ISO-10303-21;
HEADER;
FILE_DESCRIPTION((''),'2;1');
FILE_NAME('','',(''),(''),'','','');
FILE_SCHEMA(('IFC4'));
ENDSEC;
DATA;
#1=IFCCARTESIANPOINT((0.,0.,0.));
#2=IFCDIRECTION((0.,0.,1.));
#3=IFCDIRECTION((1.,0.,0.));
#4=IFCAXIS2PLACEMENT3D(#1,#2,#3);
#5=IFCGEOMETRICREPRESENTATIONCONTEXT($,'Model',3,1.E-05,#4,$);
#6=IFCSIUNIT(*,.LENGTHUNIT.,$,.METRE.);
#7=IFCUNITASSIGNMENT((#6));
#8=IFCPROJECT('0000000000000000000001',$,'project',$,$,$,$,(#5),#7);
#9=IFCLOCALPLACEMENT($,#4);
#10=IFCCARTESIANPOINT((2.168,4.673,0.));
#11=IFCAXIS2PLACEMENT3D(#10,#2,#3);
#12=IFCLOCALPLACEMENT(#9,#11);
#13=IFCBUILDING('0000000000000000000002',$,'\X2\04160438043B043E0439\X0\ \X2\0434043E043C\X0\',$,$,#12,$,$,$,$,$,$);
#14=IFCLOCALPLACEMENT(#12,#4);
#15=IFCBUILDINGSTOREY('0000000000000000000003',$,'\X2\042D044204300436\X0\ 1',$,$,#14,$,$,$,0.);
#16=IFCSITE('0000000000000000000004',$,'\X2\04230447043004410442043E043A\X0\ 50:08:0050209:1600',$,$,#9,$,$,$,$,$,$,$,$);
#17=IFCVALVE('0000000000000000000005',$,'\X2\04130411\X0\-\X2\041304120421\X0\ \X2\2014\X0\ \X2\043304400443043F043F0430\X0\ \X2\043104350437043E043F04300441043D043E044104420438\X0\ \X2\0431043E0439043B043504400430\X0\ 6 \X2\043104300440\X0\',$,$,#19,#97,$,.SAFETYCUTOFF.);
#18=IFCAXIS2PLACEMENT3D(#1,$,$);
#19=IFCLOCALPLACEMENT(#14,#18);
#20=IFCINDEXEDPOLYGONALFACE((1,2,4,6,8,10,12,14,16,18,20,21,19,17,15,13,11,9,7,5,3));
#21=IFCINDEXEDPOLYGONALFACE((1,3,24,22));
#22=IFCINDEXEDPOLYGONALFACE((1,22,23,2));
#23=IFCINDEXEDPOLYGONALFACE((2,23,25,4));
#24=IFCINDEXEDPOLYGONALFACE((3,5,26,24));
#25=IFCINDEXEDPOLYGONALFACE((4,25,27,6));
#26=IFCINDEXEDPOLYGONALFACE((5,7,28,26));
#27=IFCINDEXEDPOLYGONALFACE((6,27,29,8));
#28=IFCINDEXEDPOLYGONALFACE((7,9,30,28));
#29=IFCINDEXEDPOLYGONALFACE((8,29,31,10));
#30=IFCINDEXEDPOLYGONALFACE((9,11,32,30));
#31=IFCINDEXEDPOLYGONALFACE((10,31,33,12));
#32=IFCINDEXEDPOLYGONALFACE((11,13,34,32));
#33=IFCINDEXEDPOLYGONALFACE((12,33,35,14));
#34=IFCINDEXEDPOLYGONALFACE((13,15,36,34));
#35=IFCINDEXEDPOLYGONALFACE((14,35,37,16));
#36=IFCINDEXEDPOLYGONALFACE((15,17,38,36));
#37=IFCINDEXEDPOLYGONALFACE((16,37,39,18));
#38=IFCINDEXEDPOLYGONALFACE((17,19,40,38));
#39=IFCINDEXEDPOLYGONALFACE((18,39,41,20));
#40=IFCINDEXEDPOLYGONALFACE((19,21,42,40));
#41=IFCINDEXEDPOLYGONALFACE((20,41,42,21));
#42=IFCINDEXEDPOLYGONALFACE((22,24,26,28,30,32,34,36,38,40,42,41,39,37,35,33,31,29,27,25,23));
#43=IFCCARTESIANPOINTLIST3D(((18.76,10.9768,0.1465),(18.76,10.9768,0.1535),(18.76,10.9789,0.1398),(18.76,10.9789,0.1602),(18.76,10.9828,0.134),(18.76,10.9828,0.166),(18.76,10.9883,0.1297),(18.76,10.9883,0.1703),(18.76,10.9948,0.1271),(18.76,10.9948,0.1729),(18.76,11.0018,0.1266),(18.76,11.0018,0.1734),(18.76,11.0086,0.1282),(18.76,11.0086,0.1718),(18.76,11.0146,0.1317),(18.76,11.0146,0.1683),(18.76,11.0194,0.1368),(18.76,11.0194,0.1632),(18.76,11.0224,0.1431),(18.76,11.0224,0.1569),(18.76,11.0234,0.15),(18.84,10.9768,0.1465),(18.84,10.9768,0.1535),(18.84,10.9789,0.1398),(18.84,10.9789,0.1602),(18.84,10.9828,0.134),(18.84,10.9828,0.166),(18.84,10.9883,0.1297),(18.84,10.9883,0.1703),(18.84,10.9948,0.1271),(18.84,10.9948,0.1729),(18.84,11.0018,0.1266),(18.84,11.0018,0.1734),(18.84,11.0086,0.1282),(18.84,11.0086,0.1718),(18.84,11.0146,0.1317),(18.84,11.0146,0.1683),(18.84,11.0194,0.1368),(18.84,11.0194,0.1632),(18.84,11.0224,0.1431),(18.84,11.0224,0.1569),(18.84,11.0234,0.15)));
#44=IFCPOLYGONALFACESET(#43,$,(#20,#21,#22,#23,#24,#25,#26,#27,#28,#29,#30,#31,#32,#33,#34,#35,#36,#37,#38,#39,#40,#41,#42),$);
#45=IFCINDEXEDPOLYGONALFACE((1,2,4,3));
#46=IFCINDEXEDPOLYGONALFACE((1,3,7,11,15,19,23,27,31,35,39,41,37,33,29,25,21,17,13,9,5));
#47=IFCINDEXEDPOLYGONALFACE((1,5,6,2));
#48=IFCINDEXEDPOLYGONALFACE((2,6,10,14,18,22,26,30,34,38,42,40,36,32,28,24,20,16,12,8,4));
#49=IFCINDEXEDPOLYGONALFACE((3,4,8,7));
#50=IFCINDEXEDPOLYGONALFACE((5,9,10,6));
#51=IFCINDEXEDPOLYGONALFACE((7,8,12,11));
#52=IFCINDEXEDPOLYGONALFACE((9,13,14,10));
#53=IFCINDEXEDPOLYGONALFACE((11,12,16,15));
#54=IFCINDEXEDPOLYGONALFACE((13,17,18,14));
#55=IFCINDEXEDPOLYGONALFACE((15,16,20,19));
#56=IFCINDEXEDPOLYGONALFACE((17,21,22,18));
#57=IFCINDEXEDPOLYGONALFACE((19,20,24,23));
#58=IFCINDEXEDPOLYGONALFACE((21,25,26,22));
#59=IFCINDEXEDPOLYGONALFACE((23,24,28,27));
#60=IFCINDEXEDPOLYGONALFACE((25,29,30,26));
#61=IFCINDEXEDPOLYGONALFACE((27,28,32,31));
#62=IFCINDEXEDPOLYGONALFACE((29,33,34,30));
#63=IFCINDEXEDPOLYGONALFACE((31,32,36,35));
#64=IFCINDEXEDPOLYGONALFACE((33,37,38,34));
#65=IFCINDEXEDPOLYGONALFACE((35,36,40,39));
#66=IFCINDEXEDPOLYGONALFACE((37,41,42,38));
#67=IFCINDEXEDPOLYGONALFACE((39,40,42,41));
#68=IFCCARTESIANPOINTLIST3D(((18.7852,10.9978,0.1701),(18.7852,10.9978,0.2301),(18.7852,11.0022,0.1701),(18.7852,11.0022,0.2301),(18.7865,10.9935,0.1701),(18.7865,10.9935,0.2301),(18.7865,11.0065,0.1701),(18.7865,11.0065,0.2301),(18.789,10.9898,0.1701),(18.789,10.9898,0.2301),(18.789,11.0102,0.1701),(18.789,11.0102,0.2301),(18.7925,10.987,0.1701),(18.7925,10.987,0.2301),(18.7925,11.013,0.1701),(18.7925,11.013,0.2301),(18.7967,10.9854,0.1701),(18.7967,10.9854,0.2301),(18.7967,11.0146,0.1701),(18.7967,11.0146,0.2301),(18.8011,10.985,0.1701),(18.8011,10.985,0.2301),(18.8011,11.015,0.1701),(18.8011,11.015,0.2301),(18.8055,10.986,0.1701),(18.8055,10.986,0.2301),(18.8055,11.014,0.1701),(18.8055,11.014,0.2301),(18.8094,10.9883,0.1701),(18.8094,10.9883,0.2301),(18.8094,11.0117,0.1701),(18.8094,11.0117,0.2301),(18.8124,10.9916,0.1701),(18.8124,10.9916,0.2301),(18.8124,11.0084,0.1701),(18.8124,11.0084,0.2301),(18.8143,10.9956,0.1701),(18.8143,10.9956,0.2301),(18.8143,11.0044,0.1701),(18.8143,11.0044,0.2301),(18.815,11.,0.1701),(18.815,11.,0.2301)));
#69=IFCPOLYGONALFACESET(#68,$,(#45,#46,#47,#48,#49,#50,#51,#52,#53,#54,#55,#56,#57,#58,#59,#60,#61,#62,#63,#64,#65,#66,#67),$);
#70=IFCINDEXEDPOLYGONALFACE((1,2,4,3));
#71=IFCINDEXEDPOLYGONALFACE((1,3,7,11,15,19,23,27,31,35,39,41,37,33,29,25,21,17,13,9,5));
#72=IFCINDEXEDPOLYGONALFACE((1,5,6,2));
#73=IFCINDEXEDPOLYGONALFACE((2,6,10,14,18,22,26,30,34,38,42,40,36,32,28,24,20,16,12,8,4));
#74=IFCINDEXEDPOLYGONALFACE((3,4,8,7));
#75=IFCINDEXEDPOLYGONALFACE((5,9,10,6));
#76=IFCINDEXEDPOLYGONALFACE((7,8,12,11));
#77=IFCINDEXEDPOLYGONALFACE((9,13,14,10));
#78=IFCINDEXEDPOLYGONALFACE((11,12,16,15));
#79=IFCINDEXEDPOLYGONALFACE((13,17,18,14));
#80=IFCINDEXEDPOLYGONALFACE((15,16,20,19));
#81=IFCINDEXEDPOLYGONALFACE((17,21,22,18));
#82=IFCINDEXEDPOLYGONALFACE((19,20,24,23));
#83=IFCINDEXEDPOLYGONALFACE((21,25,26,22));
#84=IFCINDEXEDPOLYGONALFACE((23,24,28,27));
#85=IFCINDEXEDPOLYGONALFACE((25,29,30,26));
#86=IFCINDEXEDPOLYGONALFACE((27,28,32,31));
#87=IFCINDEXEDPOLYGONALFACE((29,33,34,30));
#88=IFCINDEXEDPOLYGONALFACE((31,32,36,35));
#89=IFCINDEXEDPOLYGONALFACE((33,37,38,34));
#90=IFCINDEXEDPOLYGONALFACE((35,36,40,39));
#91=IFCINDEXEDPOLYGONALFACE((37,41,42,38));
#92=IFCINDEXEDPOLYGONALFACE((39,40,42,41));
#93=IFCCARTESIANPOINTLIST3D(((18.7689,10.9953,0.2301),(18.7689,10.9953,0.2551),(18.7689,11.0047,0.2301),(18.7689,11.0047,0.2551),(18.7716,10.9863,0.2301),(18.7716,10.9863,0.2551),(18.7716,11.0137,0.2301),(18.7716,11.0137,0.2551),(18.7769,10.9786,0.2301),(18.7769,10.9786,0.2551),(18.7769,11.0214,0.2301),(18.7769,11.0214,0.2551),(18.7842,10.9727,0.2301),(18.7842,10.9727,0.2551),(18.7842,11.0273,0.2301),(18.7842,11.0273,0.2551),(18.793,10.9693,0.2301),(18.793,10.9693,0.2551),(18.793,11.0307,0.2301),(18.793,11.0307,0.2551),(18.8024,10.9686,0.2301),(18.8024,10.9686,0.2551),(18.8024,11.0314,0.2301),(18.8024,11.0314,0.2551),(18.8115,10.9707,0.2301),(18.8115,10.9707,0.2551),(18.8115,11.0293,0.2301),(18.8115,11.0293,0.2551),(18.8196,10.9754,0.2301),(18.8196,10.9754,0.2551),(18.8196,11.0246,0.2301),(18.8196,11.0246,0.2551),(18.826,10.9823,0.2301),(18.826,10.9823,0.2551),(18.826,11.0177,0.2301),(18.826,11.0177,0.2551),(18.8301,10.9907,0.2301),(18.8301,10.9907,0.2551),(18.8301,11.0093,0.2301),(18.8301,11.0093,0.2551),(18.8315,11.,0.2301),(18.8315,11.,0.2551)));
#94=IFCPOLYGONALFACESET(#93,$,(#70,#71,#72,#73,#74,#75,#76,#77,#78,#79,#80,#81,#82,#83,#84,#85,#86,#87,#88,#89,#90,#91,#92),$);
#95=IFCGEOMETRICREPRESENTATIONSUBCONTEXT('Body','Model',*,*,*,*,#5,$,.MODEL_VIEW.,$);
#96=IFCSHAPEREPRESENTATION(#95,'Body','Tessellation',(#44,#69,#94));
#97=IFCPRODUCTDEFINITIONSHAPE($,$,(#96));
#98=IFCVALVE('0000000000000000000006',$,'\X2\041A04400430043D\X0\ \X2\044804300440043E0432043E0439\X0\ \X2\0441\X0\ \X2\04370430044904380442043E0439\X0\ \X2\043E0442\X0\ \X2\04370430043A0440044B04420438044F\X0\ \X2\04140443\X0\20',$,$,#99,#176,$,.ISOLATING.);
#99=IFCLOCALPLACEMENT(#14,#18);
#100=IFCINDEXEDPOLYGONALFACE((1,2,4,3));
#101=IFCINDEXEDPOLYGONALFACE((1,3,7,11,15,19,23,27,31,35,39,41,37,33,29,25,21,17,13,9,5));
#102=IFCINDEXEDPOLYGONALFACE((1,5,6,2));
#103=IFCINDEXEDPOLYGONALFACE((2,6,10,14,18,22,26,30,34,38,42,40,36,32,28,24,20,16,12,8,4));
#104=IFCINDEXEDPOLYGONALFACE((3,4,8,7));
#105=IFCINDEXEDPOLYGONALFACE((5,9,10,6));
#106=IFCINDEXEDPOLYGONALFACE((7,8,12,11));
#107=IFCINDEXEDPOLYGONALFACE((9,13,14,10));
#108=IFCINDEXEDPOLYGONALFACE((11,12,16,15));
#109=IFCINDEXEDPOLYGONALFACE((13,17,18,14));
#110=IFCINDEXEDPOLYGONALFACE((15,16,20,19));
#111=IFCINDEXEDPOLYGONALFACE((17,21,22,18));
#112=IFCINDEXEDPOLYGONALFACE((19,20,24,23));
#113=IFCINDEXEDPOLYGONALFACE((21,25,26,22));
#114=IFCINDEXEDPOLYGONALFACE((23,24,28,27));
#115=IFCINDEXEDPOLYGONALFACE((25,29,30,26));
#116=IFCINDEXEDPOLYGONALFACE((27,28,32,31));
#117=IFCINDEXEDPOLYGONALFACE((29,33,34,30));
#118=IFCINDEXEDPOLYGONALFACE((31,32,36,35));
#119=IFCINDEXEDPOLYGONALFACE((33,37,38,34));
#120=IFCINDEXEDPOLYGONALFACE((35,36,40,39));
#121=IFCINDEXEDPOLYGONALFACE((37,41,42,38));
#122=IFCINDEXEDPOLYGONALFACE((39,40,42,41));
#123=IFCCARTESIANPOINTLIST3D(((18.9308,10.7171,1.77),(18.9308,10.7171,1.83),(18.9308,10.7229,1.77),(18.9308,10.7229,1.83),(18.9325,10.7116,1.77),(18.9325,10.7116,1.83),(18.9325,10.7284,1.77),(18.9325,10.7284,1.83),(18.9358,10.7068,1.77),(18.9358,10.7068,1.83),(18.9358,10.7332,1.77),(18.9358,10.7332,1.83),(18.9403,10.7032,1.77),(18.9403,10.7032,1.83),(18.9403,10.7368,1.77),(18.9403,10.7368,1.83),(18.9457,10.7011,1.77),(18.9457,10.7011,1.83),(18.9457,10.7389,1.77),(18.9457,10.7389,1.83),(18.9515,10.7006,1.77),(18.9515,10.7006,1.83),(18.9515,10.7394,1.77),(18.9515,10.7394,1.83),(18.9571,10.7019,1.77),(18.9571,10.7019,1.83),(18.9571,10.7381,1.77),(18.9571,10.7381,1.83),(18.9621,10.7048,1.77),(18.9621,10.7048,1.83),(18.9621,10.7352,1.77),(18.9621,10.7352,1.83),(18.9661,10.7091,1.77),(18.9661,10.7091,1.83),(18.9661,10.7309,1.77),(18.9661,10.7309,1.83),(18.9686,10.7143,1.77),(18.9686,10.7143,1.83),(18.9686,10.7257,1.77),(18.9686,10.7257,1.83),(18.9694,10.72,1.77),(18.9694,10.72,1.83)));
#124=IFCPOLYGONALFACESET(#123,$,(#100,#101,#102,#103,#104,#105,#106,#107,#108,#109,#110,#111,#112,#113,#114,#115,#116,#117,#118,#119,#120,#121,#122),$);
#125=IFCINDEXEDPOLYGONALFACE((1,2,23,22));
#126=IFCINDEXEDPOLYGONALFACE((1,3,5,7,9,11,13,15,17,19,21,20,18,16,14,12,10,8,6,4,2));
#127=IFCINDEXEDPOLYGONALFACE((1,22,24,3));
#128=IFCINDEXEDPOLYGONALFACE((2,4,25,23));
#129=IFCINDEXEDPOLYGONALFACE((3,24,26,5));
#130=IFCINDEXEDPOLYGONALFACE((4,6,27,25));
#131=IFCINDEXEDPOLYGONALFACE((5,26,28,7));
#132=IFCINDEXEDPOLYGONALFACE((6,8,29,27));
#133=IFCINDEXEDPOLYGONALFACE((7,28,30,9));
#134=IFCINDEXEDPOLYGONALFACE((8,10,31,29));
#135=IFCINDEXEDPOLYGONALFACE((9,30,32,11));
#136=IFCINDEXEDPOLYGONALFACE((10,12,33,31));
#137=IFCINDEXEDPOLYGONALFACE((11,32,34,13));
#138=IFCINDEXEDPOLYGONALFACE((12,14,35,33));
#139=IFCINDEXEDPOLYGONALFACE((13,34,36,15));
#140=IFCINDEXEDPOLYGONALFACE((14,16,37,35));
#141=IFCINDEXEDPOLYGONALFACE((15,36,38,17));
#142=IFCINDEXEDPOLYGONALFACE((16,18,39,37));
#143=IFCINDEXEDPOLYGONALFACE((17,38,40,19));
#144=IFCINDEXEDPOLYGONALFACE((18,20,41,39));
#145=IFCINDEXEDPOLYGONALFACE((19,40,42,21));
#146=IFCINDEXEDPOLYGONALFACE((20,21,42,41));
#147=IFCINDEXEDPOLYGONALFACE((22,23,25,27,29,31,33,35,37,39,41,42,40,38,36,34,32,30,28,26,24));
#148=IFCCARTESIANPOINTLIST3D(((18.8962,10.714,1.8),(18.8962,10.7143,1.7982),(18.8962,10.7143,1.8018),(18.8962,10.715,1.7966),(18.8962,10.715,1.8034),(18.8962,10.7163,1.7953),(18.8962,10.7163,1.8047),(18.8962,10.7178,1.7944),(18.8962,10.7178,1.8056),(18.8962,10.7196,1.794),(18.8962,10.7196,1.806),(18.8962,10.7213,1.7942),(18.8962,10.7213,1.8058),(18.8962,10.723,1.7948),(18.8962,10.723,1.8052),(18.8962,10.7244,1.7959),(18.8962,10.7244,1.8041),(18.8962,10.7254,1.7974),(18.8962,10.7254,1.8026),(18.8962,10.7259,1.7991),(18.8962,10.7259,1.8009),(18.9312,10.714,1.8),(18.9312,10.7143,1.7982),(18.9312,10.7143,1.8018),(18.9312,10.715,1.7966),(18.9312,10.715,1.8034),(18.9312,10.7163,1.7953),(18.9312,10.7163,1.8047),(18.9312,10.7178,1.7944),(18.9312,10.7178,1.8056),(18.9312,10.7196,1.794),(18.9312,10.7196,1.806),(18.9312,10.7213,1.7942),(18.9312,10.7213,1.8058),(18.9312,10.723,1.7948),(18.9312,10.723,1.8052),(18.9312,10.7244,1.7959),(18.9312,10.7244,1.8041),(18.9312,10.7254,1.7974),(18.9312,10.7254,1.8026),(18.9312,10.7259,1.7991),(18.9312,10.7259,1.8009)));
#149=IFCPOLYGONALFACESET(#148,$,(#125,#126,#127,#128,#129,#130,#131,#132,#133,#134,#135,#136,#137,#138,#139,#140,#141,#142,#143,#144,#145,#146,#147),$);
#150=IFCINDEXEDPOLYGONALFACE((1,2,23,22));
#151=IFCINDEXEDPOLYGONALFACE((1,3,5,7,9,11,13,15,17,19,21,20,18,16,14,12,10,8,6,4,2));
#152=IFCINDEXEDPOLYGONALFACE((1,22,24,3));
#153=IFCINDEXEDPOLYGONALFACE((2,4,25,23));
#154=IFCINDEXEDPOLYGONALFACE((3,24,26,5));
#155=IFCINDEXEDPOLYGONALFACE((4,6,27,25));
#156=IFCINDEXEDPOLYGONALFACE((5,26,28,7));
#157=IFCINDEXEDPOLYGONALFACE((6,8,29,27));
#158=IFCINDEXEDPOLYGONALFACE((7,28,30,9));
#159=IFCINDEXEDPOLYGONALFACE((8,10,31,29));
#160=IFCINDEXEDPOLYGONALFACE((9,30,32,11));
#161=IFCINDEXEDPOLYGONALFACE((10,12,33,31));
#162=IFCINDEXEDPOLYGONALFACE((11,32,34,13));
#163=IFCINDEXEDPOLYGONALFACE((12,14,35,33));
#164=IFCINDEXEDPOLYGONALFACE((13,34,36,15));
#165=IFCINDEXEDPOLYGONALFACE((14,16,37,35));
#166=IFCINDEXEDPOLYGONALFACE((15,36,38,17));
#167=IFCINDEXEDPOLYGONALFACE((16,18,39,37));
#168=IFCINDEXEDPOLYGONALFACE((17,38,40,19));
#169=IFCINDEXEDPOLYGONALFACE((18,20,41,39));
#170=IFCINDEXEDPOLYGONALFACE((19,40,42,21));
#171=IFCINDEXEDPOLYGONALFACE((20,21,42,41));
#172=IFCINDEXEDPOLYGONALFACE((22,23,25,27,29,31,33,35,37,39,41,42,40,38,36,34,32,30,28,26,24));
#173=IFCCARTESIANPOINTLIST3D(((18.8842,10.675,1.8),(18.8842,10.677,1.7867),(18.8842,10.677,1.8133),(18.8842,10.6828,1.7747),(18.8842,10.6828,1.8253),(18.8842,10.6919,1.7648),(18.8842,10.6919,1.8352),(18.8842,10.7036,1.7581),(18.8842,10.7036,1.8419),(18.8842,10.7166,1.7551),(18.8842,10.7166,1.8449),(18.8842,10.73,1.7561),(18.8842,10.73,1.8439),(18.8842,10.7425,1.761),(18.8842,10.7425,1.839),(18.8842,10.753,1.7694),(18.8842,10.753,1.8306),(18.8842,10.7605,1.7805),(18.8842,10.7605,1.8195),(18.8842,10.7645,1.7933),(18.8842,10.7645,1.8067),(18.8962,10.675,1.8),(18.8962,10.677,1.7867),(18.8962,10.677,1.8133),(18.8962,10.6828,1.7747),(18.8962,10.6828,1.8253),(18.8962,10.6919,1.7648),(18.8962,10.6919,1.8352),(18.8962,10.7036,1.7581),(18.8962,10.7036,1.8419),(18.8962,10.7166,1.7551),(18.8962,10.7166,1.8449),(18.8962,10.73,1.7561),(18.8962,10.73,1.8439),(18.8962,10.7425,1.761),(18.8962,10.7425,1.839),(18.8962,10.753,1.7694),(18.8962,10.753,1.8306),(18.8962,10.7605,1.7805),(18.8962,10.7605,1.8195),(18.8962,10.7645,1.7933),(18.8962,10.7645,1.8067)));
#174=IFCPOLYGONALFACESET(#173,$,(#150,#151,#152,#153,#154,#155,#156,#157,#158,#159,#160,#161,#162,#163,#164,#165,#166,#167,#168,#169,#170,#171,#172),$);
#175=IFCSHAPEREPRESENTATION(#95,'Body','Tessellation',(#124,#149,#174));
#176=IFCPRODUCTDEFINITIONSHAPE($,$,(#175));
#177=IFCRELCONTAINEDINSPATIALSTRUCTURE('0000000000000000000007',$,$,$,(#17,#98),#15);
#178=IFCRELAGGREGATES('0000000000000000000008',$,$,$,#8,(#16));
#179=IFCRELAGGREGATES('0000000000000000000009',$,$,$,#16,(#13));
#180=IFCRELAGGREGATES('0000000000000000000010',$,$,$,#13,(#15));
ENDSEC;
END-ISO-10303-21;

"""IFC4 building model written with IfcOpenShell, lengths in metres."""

from ifc_helpers import new_model, si_unit, frame, origin_with_axes, origin_2d, place, context, subcontext, project, spatial, circle, extrude, element, save


model = new_model("IFC4")

# Units and contexts
model_context = context("Model", 3, precision=1e-05, world=origin_with_axes())
body_context = subcontext(model_context, "Body", "Model", "MODEL_VIEW")
ifc_project = project(units=[si_unit("LENGTHUNIT", "METRE")], contexts=[model_context])

# Site, building, storey
site_placement = place(None, origin_with_axes())
site = spatial("IfcSite", under=ifc_project, at=site_placement, Name="Участок 50:08:0050209:1600")
building_placement = place(site_placement, frame((2.168, 4.673, 0.0), z_axis=(0.0, 0.0, 1.0), x_axis=(1.0, 0.0, 0.0)))
building = spatial("IfcBuilding", under=site, at=building_placement, Name="Жилой дом")
storey_placement = place(building_placement, origin_with_axes())
storey = spatial("IfcBuildingStorey", under=building, at=storey_placement, Name="Этаж 1", Elevation=0.0)

# Valves
valve_1_placement = place(storey_placement, origin_with_axes())
element("IfcValve", 1, at=valve_1_placement, inside=storey, Name="ГБ-ГВС — группа безопасности бойлера 6 бар", PredefinedType="SAFETYCUTOFF", context=body_context, shape_type="SweptSolid", body=[
    extrude(circle(Radius=0.0234, at=origin_2d()), frame((18.76, 11.0, 0.15), z_axis=(1.0, 0.0, 0.0), x_axis=(0.0, 1.0, 0.0)), (0.0, 0.0, 1.0), 0.08),
    extrude(circle(Radius=0.015, at=origin_2d()), frame((18.8, 11.0, 0.1701), z_axis=(0.0, 0.0, 1.0), x_axis=(1.0, 0.0, 0.0)), (0.0, 0.0, 1.0), 0.06),
    extrude(circle(Radius=0.0315, at=origin_2d()), frame((18.8, 11.0, 0.2301), z_axis=(0.0, 0.0, 1.0), x_axis=(1.0, 0.0, 0.0)), (0.0, 0.0, 1.0), 0.025),
])
valve_2_placement = place(storey_placement, origin_with_axes())
element("IfcValve", 2, at=valve_2_placement, inside=storey, Name="Кран шаровой с защитой от закрытия Ду20", PredefinedType="ISOLATING", context=body_context, shape_type="SweptSolid", body=[
    extrude(circle(Radius=0.0194, at=origin_2d()), frame((18.95, 10.72, 1.77), z_axis=(0.0, 0.0, 1.0), x_axis=(1.0, 0.0, 0.0)), (0.0, 0.0, 1.0), 0.06),
    extrude(circle(Radius=0.006, at=origin_2d()), frame((18.9312, 10.72, 1.8), z_axis=(-1.0, 0.0, 0.0), x_axis=(0.0, -1.0, 0.0)), (0.0, 0.0, 1.0), 0.035),
    extrude(circle(Radius=0.045, at=origin_2d()), frame((18.8962, 10.72, 1.8), z_axis=(-1.0, 0.0, 0.0), x_axis=(0.0, -1.0, 0.0)), (0.0, 0.0, 1.0), 0.012),
])

save(model, "model.ifc")
